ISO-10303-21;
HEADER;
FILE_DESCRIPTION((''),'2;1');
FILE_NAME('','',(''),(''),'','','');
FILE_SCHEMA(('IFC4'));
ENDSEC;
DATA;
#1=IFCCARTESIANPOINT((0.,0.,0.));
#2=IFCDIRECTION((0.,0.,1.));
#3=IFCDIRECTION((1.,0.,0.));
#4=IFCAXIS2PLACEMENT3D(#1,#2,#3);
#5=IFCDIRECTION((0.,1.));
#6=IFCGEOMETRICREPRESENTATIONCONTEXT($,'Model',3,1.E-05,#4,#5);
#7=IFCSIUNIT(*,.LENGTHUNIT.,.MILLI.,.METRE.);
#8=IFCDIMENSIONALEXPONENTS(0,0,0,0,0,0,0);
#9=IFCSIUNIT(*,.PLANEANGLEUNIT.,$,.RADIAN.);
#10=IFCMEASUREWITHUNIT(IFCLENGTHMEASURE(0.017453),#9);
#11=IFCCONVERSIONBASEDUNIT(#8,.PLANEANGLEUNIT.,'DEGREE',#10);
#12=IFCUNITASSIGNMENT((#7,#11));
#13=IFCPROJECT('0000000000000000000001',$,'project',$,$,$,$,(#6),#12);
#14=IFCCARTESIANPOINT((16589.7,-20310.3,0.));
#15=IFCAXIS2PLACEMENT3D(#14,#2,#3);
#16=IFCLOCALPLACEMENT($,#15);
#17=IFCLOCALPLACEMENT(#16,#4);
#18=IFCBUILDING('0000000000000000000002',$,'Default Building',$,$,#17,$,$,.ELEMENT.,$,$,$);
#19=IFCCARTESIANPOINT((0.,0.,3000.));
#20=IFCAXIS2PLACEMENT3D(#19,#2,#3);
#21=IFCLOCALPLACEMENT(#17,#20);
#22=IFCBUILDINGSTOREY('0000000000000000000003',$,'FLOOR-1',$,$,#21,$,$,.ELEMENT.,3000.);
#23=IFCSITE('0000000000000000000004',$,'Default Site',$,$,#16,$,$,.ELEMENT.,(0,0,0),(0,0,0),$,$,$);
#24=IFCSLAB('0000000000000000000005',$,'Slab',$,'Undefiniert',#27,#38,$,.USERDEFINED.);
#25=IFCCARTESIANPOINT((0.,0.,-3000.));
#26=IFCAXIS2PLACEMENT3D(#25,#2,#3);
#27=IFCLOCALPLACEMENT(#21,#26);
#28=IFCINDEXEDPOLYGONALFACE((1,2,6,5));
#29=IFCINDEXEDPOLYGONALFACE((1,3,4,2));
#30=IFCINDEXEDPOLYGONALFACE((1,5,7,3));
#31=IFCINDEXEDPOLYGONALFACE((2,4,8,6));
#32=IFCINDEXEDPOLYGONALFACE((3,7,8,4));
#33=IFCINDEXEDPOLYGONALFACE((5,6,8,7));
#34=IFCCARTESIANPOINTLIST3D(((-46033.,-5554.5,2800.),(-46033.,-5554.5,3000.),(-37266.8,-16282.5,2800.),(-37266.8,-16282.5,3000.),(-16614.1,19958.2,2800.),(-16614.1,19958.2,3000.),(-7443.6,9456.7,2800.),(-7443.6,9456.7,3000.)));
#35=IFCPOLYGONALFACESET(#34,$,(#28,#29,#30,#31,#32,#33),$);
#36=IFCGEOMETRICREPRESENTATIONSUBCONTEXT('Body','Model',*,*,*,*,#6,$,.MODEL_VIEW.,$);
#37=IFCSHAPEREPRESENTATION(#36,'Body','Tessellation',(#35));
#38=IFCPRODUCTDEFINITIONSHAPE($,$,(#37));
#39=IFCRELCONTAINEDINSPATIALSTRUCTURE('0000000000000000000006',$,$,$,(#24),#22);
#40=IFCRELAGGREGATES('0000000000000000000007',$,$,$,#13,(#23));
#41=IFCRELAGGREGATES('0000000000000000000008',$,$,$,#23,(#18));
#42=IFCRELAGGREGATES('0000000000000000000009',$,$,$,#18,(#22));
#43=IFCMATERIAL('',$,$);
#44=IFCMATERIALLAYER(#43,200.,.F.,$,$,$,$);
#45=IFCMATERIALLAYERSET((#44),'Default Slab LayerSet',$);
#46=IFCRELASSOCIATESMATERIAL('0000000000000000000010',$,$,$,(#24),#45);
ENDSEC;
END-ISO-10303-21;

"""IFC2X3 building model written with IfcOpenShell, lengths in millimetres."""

from ifc_helpers import new_model, entity, si_unit, converted_unit, direction, frame, origin_with_axes, place, context, subcontext, project, spatial, polyline, outline, extrude, material, layer, layer_set, layer_usage, element, save


model = new_model("IFC2X3")

# Units and contexts
model_context = context("Model", 3, precision=1e-05, world=origin_with_axes(), true_north=direction((0.0, 1.0)))
body_context = subcontext(model_context, "Body", "Model", "MODEL_VIEW")
ifc_project = project(units=[si_unit("LENGTHUNIT", "METRE", prefix="MILLI"), converted_unit("PLANEANGLEUNIT", "DEGREE", entity("IfcLengthMeasure", 0.017453), si_unit("PLANEANGLEUNIT", "RADIAN"), dimensions=[0, 0, 0, 0, 0, 0, 0])], contexts=[model_context])

# Site, building, storey
site_placement = place(None, frame((16589.7, -20310.3, 0.0), z_axis=(0.0, 0.0, 1.0), x_axis=(1.0, 0.0, 0.0)))
site = spatial("IfcSite", under=ifc_project, at=site_placement, Name="Default Site", CompositionType="ELEMENT", RefLatitude=(0, 0, 0), RefLongitude=(0, 0, 0))
building_placement = place(site_placement, origin_with_axes())
building = spatial("IfcBuilding", under=site, at=building_placement, Name="Default Building", CompositionType="ELEMENT")
storey_placement = place(building_placement, frame((0.0, 0.0, 3000.0), z_axis=(0.0, 0.0, 1.0), x_axis=(1.0, 0.0, 0.0)))
storey = spatial("IfcBuildingStorey", under=building, at=storey_placement, Name="FLOOR-1", CompositionType="ELEMENT", Elevation=3000.0)

# Slab
ifc_material_1 = material(Name="")
ifc_layer_1 = layer(ifc_material_1, 200.0, ventilated=False)
ifc_layer_set_1 = layer_set([ifc_layer_1], Name="Default Slab LayerSet")
ifc_layer_usage_1 = layer_usage(ifc_layer_set_1, "AXIS3", "NEGATIVE", 0.0)
slab_1_placement = place(storey_placement, frame((0.0, 0.0, -3000.0), z_axis=(0.0, 0.0, 1.0), x_axis=(1.0, 0.0, 0.0)))
element("IfcSlab", 1, at=slab_1_placement, inside=storey, material=ifc_layer_usage_1, Name="Slab", ObjectType="Undefiniert", PredefinedType="USERDEFINED", context=body_context, shape_type="SweptSolid", body=[
    extrude(outline(polyline([(81.0, 13941.8), (39021.4, 13849.1), (39394.5, 0.0), (0.0, 0.0), (81.0, 13941.8)])), frame((-7443.6, 9456.7, 2800.0), z_axis=(0.0, 0.0, -1.0), x_axis=(-0.757039, -0.65337, 0.0)), (0.0, 0.0, -1.0), 200.0),
])

save(model, "model.ifc")
